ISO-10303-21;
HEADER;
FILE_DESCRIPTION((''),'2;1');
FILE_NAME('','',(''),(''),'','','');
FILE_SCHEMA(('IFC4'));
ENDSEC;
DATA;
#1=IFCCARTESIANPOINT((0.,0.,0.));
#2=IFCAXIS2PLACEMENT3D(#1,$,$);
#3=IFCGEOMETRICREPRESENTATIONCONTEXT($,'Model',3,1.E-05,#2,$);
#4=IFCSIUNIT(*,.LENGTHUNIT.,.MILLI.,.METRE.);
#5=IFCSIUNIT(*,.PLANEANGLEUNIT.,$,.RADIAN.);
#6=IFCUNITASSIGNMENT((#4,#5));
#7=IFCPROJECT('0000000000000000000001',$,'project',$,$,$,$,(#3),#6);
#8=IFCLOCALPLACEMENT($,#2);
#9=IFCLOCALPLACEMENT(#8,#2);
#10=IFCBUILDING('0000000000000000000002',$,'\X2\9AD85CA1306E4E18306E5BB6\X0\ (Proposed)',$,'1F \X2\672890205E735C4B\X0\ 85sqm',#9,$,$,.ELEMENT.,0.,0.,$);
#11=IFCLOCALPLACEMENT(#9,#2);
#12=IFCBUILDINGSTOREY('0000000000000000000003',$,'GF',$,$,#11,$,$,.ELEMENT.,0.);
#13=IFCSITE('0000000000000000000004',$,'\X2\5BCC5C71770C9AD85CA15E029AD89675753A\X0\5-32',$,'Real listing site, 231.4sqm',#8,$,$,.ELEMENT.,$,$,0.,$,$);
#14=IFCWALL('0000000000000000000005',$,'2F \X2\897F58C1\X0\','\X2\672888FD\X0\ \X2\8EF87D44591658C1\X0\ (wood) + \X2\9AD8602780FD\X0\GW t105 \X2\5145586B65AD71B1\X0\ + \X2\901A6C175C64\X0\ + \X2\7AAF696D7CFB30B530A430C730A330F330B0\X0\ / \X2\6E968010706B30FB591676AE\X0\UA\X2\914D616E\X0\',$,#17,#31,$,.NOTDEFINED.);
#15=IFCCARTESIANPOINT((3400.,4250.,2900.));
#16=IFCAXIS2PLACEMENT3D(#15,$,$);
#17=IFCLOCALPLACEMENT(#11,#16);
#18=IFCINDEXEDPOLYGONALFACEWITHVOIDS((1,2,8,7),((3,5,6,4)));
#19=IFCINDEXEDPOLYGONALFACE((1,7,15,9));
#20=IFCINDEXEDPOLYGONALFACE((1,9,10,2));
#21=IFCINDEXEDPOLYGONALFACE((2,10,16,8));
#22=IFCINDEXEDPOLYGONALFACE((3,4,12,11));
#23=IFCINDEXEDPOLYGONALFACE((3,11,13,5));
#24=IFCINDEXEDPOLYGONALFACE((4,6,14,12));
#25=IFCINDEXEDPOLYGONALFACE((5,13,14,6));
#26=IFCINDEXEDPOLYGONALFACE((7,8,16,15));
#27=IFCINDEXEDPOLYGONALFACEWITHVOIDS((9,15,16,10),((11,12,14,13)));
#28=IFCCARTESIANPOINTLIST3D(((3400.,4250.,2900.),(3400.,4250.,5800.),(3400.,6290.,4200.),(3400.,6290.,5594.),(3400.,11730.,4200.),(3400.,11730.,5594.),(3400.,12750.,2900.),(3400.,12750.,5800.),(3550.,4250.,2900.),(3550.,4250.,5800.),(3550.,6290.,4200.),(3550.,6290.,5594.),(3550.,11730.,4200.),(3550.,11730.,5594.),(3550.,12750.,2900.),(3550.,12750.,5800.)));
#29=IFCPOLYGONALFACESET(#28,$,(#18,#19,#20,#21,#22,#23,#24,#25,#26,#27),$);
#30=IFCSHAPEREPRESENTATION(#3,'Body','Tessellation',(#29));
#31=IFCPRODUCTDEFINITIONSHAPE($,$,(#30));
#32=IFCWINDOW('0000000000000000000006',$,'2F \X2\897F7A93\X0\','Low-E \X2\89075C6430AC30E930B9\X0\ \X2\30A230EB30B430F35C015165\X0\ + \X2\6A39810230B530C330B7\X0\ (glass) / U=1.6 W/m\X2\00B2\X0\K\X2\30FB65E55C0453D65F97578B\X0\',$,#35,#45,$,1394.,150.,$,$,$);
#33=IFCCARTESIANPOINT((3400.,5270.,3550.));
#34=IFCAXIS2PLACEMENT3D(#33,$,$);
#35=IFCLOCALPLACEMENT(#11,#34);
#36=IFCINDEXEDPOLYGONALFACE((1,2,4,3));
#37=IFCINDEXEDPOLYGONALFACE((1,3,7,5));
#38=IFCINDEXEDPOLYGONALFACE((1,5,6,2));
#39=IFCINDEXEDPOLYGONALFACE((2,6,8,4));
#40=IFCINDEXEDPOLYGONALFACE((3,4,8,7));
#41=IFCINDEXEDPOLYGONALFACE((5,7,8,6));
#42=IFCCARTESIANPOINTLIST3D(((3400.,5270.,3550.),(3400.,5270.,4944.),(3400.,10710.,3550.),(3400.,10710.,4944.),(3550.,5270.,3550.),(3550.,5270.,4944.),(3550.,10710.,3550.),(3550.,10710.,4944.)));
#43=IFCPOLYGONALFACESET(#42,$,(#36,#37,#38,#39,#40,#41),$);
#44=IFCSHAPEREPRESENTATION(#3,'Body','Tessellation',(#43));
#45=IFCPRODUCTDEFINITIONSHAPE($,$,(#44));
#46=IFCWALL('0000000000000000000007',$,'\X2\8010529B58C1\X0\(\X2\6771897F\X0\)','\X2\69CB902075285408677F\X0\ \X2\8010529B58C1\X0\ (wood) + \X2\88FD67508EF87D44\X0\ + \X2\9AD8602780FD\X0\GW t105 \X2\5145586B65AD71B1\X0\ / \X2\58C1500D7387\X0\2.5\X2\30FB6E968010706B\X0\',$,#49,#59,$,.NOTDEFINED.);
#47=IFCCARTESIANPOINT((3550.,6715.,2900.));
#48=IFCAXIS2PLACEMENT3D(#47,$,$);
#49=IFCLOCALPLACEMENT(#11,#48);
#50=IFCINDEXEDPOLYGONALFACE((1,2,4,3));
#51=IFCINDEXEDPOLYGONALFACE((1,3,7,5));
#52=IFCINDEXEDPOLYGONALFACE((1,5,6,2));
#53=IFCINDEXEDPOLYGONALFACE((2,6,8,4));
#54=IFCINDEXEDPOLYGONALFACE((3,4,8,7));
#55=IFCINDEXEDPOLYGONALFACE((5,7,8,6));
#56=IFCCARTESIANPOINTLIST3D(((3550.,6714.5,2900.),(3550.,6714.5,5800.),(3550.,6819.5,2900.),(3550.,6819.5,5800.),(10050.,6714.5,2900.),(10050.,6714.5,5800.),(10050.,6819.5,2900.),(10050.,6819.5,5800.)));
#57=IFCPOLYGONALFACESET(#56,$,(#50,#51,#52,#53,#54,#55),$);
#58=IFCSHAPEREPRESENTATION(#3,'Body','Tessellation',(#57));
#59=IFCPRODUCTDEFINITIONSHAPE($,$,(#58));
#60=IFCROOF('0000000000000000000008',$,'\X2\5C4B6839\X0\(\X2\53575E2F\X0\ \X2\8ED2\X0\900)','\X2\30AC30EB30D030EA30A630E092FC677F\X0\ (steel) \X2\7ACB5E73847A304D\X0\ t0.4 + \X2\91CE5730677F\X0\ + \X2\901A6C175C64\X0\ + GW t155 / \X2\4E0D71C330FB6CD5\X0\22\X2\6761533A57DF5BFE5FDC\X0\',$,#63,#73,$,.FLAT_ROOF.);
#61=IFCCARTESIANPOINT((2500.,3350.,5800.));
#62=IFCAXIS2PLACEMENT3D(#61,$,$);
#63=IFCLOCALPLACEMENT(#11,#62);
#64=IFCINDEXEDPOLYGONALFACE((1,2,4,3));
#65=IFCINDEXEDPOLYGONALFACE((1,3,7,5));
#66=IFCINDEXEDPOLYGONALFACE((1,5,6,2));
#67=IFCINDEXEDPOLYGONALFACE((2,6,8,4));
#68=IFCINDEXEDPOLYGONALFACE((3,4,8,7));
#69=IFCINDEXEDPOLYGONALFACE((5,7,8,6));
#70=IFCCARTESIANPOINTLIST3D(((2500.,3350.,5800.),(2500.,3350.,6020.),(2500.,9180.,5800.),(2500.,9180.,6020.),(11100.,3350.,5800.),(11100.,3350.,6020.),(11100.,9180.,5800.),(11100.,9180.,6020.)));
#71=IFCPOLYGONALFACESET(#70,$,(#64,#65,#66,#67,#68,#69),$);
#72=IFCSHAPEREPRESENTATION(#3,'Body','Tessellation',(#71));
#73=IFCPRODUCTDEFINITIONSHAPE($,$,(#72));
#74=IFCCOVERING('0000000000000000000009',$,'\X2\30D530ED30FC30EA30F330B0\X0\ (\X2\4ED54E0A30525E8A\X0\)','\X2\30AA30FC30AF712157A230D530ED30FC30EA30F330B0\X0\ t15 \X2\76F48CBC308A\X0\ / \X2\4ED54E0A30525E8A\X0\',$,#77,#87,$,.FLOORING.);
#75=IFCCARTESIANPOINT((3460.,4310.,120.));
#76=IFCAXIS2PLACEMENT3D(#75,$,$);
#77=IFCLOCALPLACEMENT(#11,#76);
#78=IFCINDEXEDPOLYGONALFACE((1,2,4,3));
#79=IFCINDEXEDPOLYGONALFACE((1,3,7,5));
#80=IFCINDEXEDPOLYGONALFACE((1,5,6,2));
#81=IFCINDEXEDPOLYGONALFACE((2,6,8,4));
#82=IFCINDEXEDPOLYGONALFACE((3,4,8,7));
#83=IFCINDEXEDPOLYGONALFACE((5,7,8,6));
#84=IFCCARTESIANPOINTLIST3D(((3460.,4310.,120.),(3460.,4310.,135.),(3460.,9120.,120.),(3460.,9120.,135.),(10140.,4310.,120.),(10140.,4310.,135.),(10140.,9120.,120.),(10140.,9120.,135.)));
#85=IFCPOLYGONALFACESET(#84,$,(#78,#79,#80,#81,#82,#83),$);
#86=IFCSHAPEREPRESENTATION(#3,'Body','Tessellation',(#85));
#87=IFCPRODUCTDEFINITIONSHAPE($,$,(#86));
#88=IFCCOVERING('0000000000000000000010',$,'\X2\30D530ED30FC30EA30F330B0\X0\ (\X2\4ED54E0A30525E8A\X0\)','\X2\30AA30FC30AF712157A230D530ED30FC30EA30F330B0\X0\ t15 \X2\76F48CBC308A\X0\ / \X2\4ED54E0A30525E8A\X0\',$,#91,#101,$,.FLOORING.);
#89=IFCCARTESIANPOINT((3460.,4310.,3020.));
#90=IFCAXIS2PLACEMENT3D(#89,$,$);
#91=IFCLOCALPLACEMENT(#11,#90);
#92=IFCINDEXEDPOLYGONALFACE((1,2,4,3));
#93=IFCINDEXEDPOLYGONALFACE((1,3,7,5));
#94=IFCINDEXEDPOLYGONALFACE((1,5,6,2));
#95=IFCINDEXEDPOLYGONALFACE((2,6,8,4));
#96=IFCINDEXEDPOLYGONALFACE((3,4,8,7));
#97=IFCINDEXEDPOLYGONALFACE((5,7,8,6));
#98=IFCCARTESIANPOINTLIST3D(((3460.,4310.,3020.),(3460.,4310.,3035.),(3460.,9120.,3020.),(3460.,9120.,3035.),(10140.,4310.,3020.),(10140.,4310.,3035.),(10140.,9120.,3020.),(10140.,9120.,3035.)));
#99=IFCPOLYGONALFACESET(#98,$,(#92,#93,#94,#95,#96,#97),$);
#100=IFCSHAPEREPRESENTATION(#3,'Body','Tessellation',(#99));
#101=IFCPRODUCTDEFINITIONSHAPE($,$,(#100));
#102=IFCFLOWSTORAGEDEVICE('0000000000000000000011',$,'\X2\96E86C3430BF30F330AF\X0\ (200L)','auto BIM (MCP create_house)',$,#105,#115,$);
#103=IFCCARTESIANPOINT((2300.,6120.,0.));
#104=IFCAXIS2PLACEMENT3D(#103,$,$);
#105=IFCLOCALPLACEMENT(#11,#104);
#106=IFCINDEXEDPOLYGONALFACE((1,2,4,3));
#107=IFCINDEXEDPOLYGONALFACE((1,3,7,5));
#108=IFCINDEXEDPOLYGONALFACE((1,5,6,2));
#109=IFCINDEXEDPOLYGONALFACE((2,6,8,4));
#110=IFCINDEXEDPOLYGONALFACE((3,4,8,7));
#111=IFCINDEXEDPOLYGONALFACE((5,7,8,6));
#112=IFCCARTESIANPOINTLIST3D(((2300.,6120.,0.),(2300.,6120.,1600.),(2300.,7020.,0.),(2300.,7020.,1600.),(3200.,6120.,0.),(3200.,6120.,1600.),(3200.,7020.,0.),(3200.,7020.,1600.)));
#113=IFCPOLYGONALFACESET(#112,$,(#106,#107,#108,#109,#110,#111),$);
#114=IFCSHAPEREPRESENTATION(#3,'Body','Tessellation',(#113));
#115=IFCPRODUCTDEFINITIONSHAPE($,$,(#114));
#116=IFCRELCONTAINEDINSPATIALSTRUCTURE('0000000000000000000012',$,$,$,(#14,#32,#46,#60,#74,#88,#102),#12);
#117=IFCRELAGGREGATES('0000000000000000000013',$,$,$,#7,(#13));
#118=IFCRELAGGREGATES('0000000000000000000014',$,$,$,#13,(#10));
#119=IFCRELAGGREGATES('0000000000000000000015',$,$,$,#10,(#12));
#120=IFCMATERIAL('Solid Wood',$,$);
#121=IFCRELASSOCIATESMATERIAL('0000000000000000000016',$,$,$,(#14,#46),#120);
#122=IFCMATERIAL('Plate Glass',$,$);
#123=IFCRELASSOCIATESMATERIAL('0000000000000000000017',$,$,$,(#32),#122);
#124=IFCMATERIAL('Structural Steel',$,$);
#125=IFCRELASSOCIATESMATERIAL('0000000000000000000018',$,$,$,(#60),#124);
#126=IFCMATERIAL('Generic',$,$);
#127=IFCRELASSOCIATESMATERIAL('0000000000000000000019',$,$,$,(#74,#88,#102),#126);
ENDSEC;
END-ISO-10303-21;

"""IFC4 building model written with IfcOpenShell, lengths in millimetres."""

from ifc_helpers import new_model, si_unit, frame, frame_2d, origin, place, context, project, spatial, rectangle, extrude, material, element, fill, save


model = new_model("IFC4")

# Units and contexts
model_context = context("Model", 3, precision=1e-05, world=origin())
ifc_project = project(units=[si_unit("LENGTHUNIT", "METRE", prefix="MILLI"), si_unit("PLANEANGLEUNIT", "RADIAN")], contexts=[model_context])

# Site, building, storey
site_placement = place(None, origin())
site = spatial("IfcSite", under=ifc_project, at=site_placement, Name="富山県高岡市高陵町5-32", ObjectType="Real listing site, 231.4sqm", CompositionType="ELEMENT", RefElevation=0.0)
building_placement = place(site_placement, origin())
building = spatial("IfcBuilding", under=site, at=building_placement, Name="高岡の丘の家 (Proposed)", ObjectType="1F 木造平屋 85sqm", CompositionType="ELEMENT", ElevationOfRefHeight=0.0, ElevationOfTerrain=0.0)
storey_placement = place(building_placement, origin())
storey = spatial("IfcBuildingStorey", under=building, at=storey_placement, Name="GF", CompositionType="ELEMENT", Elevation=0.0)

# Shared definitions
ifc_material_1 = material(Name="Solid Wood")
ifc_material_2 = material(Name="Generic")

# Shared definitions
ifc_material_3 = material(Name="Plate Glass")

# Wall, opening, window
wall_1_placement = place(storey_placement, frame((3400.0, 4250.0, 2900.0)))
wall_1 = element("IfcWall", 1, at=wall_1_placement, inside=storey, material=ifc_material_1, Name="2F 西壁", Description="木製 軸組外壁 (wood) + 高性能GW t105 充填断熱 + 通気層 + 窯業系サイディング / 準耐火・外皮UA配慮", PredefinedType="NOTDEFINED", context=model_context, shape_type="SweptSolid", body=[
    extrude(rectangle(XDim=150.0, YDim=8500.0, at=frame_2d((75.0, 4250.0))), frame((3400.0, 4250.0, 2900.0)), (0.0, 0.0, 1.0), 2900.0),
])
opening_1_placement = place(storey_placement, frame((3400.0, 5270.0, 3550.0)))
opening_1 = element("IfcOpeningElement", 2, at=opening_1_placement, cuts=wall_1, PredefinedType="NOTDEFINED", context=model_context, shape_type="SweptSolid", body=[
    extrude(rectangle(XDim=150.0, YDim=5440.0, at=frame_2d((75.0, 2720.0))), frame((3400.0, 5270.0, 3550.0)), (0.0, 0.0, 1.0), 1394.0),
])
window_1_placement = place(storey_placement, frame((3400.0, 5270.0, 3550.0)))
window_1 = element("IfcWindow", 3, at=window_1_placement, inside=storey, material=ifc_material_3, Name="2F 西窓", Description="Low-E 複層ガラス アルゴン封入 + 樹脂サッシ (glass) / U=1.6 W/m²K・日射取得型", OverallHeight=1394.0, OverallWidth=150.0, context=model_context, shape_type="SweptSolid", body=[
    extrude(rectangle(XDim=150.0, YDim=5440.0, at=frame_2d((75.0, 2720.0))), frame((3400.0, 5270.0, 3550.0)), (0.0, 0.0, 1.0), 1394.0),
])
fill(opening_1, window_1)

# Wall
wall_2_placement = place(storey_placement, frame((3550.0, 6715.0, 2900.0)))
element("IfcWall", 4, at=wall_2_placement, inside=storey, material=ifc_material_1, Name="耐力壁(東西)", Description="構造用合板 耐力壁 (wood) + 製材軸組 + 高性能GW t105 充填断熱 / 壁倍率2.5・準耐火", PredefinedType="NOTDEFINED", context=model_context, shape_type="SweptSolid", body=[
    extrude(rectangle(XDim=6500.0, YDim=105.0, at=frame_2d((3250.0, 52.0))), frame((3550.0, 6715.0, 2900.0)), (0.0, 0.0, 1.0), 2900.0),
])

# Roof
ifc_material_4 = material(Name="Structural Steel")
for number, where, name in (
    (5, (2500.0, 3350.0, 5800.0), "屋根(南帯 軒900)"),
):
    element("IfcRoof", number, at=place(storey_placement, frame(where)), inside=storey, material=ifc_material_4, Name=name, Description="ガルバリウム鋼板 (steel) 立平葺き t0.4 + 野地板 + 通気層 + GW t155 / 不燃・法22条区域対応", PredefinedType="FLAT_ROOF", context=model_context, shape_type="SweptSolid", body=[
        extrude(rectangle(XDim=8600.0, YDim=5830.0, at=frame_2d((4300.0, 2915.0))), frame((2500.0, 3350.0, 5800.0)), (0.0, 0.0, 1.0), 220.0),
    ])

# Coverings
covering_1_placement = place(storey_placement, frame((3460.0, 4310.0, 120.0)))
element("IfcCovering", 6, at=covering_1_placement, inside=storey, material=ifc_material_2, Name="フローリング (仕上げ床)", Description="オーク無垢フローリング t15 直貼り / 仕上げ床", PredefinedType="FLOORING", context=model_context, shape_type="SweptSolid", body=[
    extrude(rectangle(XDim=6680.0, YDim=4810.0, at=frame_2d((3340.0, 2405.0))), frame((3460.0, 4310.0, 120.0)), (0.0, 0.0, 1.0), 15.0),
])
covering_2_placement = place(storey_placement, frame((3460.0, 4310.0, 3020.0)))
element("IfcCovering", 7, at=covering_2_placement, inside=storey, material=ifc_material_2, Name="フローリング (仕上げ床)", Description="オーク無垢フローリング t15 直貼り / 仕上げ床", PredefinedType="FLOORING", context=model_context, shape_type="SweptSolid", body=[
    extrude(rectangle(XDim=6680.0, YDim=4810.0, at=frame_2d((3340.0, 2405.0))), frame((3460.0, 4310.0, 3020.0)), (0.0, 0.0, 1.0), 15.0),
])

# Flow storage device
flow_storage_device_placement = place(storey_placement, frame((2300.0, 6120.0, 0.0)))
element("IfcFlowStorageDevice", 8, at=flow_storage_device_placement, inside=storey, material=ifc_material_2, Name="雨水タンク (200L)", Description="auto BIM (MCP create_house)", context=model_context, shape_type="SweptSolid", body=[
    extrude(rectangle(XDim=900.0, YDim=900.0, at=frame_2d((450.0, 450.0))), frame((2300.0, 6120.0, 0.0)), (0.0, 0.0, 1.0), 1600.0),
])

save(model, "model.ifc")
